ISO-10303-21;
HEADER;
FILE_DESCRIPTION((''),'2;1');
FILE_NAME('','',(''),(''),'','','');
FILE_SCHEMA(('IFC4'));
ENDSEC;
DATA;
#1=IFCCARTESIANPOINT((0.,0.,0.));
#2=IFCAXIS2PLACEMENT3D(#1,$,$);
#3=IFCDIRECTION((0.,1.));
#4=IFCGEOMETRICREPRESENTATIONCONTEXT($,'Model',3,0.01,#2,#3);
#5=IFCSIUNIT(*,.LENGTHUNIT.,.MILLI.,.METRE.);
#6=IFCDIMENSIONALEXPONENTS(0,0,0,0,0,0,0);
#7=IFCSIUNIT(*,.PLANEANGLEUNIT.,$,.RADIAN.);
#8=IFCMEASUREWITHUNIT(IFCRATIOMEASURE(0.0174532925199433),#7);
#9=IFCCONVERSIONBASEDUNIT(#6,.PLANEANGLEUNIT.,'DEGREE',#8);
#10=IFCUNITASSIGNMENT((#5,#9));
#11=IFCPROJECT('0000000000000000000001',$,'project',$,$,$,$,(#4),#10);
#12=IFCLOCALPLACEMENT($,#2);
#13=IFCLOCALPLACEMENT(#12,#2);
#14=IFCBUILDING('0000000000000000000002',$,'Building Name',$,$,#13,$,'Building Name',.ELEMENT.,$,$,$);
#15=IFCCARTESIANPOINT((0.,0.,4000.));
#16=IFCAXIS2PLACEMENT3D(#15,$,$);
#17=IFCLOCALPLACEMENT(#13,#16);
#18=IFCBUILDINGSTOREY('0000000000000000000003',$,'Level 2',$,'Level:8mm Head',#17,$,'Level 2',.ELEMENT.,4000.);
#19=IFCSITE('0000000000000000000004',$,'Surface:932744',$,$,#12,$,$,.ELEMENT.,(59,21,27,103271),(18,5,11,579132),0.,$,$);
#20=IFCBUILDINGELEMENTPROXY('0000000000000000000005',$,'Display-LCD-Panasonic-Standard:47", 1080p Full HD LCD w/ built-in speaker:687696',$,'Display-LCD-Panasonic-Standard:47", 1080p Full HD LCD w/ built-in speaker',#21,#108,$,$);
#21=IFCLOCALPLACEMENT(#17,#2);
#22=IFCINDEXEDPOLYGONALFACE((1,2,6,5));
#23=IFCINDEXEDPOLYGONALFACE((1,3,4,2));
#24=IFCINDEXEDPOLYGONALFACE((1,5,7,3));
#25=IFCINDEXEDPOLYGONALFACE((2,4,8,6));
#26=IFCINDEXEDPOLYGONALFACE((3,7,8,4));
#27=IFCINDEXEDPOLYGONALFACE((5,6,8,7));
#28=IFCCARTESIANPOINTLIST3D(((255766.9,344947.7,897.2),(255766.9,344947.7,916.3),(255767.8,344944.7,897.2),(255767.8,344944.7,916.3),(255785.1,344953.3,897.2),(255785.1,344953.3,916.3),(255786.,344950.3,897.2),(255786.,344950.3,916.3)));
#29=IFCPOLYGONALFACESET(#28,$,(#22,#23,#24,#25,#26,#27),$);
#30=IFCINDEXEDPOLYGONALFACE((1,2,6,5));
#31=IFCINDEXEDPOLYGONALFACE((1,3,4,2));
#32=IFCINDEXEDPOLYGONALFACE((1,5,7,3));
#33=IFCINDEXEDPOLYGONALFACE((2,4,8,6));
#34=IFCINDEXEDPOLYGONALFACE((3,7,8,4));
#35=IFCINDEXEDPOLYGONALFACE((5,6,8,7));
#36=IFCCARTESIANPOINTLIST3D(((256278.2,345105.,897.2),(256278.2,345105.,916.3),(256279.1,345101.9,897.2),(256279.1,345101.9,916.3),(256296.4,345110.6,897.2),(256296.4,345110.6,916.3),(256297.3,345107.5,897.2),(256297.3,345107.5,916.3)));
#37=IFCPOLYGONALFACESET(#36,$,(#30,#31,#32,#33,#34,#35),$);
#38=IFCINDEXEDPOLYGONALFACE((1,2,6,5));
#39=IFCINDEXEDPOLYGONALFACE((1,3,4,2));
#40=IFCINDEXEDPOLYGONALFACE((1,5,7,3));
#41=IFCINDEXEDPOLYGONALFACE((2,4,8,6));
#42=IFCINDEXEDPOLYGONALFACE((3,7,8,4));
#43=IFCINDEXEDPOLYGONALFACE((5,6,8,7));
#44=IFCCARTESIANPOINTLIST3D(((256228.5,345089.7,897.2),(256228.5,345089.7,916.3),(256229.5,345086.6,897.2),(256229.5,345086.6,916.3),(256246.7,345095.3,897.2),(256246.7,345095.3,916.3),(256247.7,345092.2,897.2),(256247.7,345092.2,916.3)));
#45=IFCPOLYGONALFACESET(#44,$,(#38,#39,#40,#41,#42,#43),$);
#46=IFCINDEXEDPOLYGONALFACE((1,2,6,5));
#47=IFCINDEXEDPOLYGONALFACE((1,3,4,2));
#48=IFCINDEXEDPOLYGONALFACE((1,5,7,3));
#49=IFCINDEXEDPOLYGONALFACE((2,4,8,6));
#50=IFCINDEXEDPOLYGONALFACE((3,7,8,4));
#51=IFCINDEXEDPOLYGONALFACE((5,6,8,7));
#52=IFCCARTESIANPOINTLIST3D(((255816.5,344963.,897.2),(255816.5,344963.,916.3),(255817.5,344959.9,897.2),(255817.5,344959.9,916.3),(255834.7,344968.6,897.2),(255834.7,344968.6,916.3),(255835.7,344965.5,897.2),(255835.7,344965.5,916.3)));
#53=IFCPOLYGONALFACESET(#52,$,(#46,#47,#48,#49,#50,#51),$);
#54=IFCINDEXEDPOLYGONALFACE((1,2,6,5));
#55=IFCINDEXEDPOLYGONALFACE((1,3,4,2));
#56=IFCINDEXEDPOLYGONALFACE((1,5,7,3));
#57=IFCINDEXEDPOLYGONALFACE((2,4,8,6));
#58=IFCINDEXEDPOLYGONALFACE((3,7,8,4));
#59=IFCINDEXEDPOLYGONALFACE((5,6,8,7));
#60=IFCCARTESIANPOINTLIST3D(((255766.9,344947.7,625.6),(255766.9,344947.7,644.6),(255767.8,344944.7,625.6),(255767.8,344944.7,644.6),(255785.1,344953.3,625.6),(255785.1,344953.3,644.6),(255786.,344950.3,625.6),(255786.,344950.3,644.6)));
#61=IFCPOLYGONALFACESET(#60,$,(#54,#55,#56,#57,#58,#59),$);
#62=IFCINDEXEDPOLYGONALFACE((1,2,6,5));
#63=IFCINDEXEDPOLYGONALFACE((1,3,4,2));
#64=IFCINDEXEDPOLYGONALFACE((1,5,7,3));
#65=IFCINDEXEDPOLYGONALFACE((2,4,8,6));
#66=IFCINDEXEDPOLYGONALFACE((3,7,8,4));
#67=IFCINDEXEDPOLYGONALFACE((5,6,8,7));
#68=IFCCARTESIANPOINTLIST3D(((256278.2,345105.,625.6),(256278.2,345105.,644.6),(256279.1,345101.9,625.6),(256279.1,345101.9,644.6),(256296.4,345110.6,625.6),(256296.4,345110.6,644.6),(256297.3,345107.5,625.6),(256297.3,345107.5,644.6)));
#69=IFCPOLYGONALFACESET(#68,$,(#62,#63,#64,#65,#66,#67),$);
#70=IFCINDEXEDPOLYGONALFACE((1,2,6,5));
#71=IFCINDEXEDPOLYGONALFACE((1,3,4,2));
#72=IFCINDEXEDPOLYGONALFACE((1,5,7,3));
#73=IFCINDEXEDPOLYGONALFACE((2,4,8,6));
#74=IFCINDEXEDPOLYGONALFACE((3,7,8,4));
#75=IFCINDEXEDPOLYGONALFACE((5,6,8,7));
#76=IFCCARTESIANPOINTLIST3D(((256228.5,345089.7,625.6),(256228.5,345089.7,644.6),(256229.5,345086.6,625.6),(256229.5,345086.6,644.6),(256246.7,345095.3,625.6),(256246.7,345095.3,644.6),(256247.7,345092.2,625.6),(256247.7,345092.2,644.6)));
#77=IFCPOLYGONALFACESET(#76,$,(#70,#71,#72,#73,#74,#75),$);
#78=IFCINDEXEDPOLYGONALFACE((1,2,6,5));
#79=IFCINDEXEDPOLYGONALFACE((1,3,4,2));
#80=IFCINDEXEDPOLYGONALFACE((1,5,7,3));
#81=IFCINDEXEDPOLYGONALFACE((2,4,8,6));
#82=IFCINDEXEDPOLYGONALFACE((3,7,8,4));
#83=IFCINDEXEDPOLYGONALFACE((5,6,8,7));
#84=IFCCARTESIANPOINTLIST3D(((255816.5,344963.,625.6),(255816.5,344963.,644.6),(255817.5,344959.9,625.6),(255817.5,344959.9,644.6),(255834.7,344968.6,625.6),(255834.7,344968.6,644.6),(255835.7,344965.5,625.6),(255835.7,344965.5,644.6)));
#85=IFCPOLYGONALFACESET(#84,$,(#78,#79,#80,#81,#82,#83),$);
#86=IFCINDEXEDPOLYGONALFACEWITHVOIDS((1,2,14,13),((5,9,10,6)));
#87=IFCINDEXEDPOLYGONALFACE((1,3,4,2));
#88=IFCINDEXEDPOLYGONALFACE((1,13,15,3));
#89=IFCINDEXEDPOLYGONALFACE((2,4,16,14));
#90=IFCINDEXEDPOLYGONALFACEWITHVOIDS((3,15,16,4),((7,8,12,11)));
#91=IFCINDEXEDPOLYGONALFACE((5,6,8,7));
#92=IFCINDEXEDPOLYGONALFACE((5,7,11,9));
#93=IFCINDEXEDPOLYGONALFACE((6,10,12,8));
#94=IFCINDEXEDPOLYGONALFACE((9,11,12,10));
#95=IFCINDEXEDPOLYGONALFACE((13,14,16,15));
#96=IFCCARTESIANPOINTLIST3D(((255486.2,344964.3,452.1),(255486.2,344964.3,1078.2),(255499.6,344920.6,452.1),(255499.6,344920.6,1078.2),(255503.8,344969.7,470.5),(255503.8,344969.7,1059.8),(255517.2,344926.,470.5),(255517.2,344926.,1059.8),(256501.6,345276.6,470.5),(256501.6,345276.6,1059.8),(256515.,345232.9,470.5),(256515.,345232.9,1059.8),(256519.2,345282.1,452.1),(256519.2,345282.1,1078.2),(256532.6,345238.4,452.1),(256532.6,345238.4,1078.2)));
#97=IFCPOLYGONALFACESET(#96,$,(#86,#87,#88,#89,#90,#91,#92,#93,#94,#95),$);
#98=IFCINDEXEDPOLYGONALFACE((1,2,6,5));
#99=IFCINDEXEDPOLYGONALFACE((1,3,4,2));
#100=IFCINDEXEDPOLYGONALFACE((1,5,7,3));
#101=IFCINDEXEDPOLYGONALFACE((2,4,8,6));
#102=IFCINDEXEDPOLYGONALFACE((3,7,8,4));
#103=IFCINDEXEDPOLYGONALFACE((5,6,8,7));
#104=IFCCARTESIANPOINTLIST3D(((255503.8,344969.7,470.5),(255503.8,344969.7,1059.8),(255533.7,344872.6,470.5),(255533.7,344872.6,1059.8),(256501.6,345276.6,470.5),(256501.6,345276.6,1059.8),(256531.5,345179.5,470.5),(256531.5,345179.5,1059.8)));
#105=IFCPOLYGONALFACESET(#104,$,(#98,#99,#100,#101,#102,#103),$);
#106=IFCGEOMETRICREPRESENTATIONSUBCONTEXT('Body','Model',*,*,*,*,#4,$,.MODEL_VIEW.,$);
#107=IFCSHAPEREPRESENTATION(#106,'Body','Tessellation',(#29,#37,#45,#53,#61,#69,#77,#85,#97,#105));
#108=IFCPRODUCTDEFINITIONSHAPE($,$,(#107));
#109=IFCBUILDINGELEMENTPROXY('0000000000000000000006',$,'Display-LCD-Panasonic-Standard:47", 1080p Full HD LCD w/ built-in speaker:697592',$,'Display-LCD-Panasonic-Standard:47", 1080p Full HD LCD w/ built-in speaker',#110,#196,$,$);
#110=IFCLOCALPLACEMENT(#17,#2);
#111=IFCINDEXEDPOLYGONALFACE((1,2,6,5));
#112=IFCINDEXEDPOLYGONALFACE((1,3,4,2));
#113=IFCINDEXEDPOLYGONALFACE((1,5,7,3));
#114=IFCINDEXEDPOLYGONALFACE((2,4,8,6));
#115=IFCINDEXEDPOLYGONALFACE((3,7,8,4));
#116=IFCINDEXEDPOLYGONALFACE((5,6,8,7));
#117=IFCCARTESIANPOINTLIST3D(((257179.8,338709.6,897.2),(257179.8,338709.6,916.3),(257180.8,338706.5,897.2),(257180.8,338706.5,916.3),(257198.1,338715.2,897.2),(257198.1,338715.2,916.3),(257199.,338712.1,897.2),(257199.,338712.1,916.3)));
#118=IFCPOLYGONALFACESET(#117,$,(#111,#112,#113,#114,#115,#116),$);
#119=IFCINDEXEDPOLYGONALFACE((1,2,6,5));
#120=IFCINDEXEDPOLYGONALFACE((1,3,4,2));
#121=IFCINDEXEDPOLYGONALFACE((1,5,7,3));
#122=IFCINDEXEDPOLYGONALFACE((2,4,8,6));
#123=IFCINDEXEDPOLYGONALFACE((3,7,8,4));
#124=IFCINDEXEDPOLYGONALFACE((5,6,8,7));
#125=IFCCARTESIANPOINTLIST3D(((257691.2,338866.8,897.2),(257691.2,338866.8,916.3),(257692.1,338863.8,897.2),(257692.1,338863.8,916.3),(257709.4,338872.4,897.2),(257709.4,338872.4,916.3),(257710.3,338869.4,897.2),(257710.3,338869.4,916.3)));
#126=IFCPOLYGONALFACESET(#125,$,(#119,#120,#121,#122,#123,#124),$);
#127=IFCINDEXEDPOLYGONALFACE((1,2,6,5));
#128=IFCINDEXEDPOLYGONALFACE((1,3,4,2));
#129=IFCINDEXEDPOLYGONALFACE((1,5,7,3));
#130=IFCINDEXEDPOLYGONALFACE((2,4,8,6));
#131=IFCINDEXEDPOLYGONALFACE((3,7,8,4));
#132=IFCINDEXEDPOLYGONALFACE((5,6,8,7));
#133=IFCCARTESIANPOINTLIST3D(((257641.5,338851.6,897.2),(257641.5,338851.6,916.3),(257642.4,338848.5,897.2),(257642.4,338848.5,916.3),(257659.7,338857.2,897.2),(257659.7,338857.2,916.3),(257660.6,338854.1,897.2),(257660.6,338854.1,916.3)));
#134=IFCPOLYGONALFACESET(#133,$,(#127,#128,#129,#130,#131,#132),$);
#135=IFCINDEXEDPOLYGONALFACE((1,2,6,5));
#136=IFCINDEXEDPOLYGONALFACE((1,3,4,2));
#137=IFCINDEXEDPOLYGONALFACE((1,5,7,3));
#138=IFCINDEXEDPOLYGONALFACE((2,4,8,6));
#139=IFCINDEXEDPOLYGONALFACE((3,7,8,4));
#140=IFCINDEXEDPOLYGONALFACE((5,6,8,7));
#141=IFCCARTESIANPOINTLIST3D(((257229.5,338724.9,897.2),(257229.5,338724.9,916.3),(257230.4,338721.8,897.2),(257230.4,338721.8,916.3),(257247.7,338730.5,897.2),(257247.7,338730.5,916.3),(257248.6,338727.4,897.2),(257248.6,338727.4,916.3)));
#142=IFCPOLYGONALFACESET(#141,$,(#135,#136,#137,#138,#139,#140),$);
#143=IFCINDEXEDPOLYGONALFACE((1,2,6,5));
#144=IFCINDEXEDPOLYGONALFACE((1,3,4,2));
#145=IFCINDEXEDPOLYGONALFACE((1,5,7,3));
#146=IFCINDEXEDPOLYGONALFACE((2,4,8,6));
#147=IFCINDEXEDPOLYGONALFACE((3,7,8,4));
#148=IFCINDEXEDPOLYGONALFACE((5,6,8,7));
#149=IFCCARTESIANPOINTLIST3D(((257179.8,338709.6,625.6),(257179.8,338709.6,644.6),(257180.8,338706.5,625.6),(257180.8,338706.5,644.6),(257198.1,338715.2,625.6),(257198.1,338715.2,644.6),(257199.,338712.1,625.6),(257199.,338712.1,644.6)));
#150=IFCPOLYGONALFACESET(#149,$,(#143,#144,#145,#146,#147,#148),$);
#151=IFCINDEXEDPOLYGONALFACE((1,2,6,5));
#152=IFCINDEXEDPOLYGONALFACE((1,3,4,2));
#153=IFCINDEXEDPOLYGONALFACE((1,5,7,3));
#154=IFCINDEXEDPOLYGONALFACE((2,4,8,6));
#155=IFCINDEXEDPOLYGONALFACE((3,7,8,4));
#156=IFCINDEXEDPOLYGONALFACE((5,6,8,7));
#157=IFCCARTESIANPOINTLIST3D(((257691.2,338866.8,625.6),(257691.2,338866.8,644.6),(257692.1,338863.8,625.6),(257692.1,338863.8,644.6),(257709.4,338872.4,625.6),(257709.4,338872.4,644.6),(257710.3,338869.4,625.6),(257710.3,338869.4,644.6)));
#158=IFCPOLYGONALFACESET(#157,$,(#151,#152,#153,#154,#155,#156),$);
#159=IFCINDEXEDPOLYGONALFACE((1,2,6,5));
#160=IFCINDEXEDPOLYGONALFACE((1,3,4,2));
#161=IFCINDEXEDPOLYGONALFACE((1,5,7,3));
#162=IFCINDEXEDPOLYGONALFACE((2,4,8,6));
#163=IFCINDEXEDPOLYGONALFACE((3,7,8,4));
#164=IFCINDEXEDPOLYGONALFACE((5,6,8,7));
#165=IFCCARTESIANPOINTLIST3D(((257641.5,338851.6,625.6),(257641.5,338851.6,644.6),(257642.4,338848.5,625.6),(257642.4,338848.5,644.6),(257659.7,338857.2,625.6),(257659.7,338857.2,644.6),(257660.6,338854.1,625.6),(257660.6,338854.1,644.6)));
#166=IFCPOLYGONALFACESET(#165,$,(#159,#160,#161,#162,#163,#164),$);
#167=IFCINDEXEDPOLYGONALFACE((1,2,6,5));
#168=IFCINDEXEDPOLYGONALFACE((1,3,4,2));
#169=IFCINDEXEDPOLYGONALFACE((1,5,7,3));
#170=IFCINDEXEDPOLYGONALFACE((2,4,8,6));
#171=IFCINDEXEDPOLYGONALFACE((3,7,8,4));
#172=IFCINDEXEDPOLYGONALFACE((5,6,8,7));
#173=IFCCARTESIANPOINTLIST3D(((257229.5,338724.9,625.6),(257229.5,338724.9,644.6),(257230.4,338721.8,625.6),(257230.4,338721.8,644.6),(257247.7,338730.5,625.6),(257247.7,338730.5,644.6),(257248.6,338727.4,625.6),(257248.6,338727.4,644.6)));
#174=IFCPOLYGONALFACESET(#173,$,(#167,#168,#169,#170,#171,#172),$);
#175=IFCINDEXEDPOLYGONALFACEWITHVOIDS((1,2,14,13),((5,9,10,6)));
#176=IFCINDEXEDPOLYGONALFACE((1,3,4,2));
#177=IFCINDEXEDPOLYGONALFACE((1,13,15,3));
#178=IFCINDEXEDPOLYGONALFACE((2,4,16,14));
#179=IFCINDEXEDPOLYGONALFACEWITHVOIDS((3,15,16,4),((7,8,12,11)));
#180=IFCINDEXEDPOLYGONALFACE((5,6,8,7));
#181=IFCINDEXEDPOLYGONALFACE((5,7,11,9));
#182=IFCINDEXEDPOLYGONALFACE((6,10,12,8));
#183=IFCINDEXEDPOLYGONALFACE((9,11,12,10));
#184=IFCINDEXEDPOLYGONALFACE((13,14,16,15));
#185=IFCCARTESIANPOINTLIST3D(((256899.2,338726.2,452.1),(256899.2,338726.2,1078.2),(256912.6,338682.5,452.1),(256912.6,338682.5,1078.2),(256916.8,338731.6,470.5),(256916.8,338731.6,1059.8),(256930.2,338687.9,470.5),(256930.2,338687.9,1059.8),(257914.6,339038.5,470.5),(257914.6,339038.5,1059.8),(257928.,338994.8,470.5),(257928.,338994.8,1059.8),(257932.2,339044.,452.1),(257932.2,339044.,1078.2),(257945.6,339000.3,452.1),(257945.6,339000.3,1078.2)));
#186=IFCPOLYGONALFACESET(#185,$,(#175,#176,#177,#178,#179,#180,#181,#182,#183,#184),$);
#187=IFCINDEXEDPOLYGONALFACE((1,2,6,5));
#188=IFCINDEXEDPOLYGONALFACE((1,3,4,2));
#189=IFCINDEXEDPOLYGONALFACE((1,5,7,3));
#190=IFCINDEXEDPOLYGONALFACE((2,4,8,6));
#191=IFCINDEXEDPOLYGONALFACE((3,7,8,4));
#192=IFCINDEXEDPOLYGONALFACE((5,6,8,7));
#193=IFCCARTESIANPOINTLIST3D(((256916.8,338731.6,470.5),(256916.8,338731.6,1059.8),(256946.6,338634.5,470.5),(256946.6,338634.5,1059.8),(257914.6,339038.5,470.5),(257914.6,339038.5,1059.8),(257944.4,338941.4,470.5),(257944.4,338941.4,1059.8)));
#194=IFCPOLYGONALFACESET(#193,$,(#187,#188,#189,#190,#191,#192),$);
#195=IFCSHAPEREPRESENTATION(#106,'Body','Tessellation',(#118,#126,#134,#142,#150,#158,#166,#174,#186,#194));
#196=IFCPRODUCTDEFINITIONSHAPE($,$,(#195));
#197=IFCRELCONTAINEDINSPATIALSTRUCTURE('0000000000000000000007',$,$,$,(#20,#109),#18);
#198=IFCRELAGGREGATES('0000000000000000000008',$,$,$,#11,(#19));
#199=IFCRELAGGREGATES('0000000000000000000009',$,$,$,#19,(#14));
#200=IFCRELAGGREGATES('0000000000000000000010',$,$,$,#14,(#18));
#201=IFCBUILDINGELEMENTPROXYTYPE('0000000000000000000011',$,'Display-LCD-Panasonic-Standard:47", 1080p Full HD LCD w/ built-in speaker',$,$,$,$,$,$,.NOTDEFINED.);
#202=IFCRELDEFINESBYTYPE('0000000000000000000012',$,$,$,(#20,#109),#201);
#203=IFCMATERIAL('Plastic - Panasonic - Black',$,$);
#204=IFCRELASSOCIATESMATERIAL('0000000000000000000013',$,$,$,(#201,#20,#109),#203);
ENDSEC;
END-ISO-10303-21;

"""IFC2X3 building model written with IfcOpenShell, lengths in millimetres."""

from ifc_helpers import new_model, entity, si_unit, converted_unit, direction, frame, frame_2d, origin, origin_2d_with_axis, place, context, subcontext, project, spatial, polyline, rectangle, outline, extrude, source, transform, mapped, material, type_object, type_shapes, element, save


model = new_model("IFC2X3")

# Units and contexts
model_context = context("Model", 3, precision=0.01, world=origin(), true_north=direction((0.0, 1.0)))
body_context = subcontext(model_context, "Body", "Model", "MODEL_VIEW")
ifc_project = project(units=[si_unit("LENGTHUNIT", "METRE", prefix="MILLI"), converted_unit("PLANEANGLEUNIT", "DEGREE", entity("IfcRatioMeasure", 0.0174532925199433), si_unit("PLANEANGLEUNIT", "RADIAN"), dimensions=[0, 0, 0, 0, 0, 0, 0])], contexts=[model_context])

# Site, building, storey
site_placement = place(None, origin())
site = spatial("IfcSite", under=ifc_project, at=site_placement, Name="Surface:932744", CompositionType="ELEMENT", RefLatitude=(59, 21, 27, 103271), RefLongitude=(18, 5, 11, 579132), RefElevation=0.0)
building_placement = place(site_placement, origin())
building = spatial("IfcBuilding", under=site, at=building_placement, Name="Building Name", LongName="Building Name", CompositionType="ELEMENT")
storey_placement = place(building_placement, frame((0.0, 0.0, 4000.0)))
storey = spatial("IfcBuildingStorey", under=building, at=storey_placement, Name="Level 2", ObjectType="Level:8mm Head", LongName="Level 2", CompositionType="ELEMENT", Elevation=4000.0)

# Building element proxies
ifc_material = material(Name="Plastic - Panasonic - Black")
building_element_proxy_type = type_object("IfcBuildingElementProxyType", Name="Display-LCD-Panasonic-Standard:47\", 1080p Full HD LCD w/ built-in speaker", PredefinedType="NOTDEFINED", material=ifc_material)
shared_shape = source(origin(), body_context, "Body", "SweptSolid", [
    extrude(rectangle(XDim=19.0, YDim=19.1, at=origin_2d_with_axis()), frame((267.5, 187.5, 0.0), z_axis=(0.0, 0.0, 1.0), x_axis=(0.0, 1.0, 0.0)), (0.0, 0.0, 1.0), 3.2),
    extrude(rectangle(XDim=19.0, YDim=19.1, at=origin_2d_with_axis()), frame((-267.5, 187.5, 0.0), z_axis=(0.0, 0.0, 1.0), x_axis=(0.0, 1.0, 0.0)), (0.0, 0.0, 1.0), 3.2),
    extrude(rectangle(XDim=19.0, YDim=19.0, at=origin_2d_with_axis()), frame((-215.5, 187.5, 0.0), z_axis=(0.0, 0.0, 1.0), x_axis=(0.0, 1.0, 0.0)), (0.0, 0.0, 1.0), 3.2),
    extrude(rectangle(XDim=19.0, YDim=19.0, at=frame_2d((0.0, 0.0), x_axis=(1.0, 0.0))), frame((215.5, 187.5, 0.0), z_axis=(0.0, 0.0, 1.0), x_axis=(0.0, 1.0, 0.0)), (0.0, 0.0, 1.0), 3.2),
    extrude(rectangle(XDim=19.0, YDim=19.1, at=frame_2d((0.0, 0.0), x_axis=(1.0, 0.0))), frame((267.5, -84.1, 0.0), z_axis=(0.0, 0.0, 1.0), x_axis=(0.0, 1.0, 0.0)), (0.0, 0.0, 1.0), 3.2),
    extrude(rectangle(XDim=19.0, YDim=19.1, at=frame_2d((0.0, 0.0), x_axis=(1.0, 0.0))), frame((-267.5, -84.1, 0.0), z_axis=(0.0, 0.0, 1.0), x_axis=(0.0, 1.0, 0.0)), (0.0, 0.0, 1.0), 3.2),
    extrude(rectangle(XDim=19.0, YDim=19.0, at=frame_2d((0.0, 0.0), x_axis=(1.0, 0.0))), frame((-215.5, -84.1, 0.0), z_axis=(0.0, 0.0, 1.0), x_axis=(0.0, 1.0, 0.0)), (0.0, 0.0, 1.0), 3.2),
    extrude(rectangle(XDim=19.0, YDim=19.0, at=frame_2d((0.0, 0.0), x_axis=(1.0, 0.0))), frame((215.5, -84.1, 0.0), z_axis=(0.0, 0.0, 1.0), x_axis=(0.0, 1.0, 0.0)), (0.0, 0.0, 1.0), 3.2),
    extrude(outline(polyline([(-313.1, -540.4), (313.1, -540.4), (313.1, 540.4), (-313.1, 540.4), (-313.1, -540.4)]), holes=[polyline([(294.6, -522.0), (-294.6, -522.0), (-294.6, 522.0), (294.6, 522.0), (294.6, -522.0)])]), frame((0.0, 46.0, 55.9), z_axis=(0.0, 0.0, 1.0), x_axis=(0.0, 1.0, 0.0)), (0.0, 0.0, 1.0), 45.7),
    extrude(rectangle(XDim=1043.9, YDim=589.3, at=frame_2d((0.0, 0.0), x_axis=(1.0, 0.0))), frame((0.0, 46.0, 0.0), z_axis=(0.0, 0.0, 1.0), x_axis=(-1.0, 0.0, 0.0)), (0.0, 0.0, 1.0), 101.6),
])
type_shapes(building_element_proxy_type, [shared_shape])
for number, where, z_axis, x_axis, name in (
    (1, (256032.6, 345026.1, 719.2), (-0.29398, 0.955811, 0.0), (-0.955811, -0.29398, 0.0), "Display-LCD-Panasonic-Standard:47\", 1080p Full HD LCD w/ built-in speaker:687696"),
    (2, (257445.5, 338788.0, 719.2), (-0.29398, 0.955811, 0.0), (-0.955811, -0.29398, 0.0), "Display-LCD-Panasonic-Standard:47\", 1080p Full HD LCD w/ built-in speaker:697592"),
):
    element("IfcBuildingElementProxy", number, at=place(storey_placement, frame(where, z_axis=z_axis, x_axis=x_axis)), inside=storey, type_object=building_element_proxy_type, material=ifc_material, Name=name, ObjectType="Display-LCD-Panasonic-Standard:47\", 1080p Full HD LCD w/ built-in speaker", context=body_context, shape_type="MappedRepresentation", body=[
        mapped(shared_shape, transform((0.0, 0.0, 0.0), scale=1.0)),
    ])

save(model, "model.ifc")
